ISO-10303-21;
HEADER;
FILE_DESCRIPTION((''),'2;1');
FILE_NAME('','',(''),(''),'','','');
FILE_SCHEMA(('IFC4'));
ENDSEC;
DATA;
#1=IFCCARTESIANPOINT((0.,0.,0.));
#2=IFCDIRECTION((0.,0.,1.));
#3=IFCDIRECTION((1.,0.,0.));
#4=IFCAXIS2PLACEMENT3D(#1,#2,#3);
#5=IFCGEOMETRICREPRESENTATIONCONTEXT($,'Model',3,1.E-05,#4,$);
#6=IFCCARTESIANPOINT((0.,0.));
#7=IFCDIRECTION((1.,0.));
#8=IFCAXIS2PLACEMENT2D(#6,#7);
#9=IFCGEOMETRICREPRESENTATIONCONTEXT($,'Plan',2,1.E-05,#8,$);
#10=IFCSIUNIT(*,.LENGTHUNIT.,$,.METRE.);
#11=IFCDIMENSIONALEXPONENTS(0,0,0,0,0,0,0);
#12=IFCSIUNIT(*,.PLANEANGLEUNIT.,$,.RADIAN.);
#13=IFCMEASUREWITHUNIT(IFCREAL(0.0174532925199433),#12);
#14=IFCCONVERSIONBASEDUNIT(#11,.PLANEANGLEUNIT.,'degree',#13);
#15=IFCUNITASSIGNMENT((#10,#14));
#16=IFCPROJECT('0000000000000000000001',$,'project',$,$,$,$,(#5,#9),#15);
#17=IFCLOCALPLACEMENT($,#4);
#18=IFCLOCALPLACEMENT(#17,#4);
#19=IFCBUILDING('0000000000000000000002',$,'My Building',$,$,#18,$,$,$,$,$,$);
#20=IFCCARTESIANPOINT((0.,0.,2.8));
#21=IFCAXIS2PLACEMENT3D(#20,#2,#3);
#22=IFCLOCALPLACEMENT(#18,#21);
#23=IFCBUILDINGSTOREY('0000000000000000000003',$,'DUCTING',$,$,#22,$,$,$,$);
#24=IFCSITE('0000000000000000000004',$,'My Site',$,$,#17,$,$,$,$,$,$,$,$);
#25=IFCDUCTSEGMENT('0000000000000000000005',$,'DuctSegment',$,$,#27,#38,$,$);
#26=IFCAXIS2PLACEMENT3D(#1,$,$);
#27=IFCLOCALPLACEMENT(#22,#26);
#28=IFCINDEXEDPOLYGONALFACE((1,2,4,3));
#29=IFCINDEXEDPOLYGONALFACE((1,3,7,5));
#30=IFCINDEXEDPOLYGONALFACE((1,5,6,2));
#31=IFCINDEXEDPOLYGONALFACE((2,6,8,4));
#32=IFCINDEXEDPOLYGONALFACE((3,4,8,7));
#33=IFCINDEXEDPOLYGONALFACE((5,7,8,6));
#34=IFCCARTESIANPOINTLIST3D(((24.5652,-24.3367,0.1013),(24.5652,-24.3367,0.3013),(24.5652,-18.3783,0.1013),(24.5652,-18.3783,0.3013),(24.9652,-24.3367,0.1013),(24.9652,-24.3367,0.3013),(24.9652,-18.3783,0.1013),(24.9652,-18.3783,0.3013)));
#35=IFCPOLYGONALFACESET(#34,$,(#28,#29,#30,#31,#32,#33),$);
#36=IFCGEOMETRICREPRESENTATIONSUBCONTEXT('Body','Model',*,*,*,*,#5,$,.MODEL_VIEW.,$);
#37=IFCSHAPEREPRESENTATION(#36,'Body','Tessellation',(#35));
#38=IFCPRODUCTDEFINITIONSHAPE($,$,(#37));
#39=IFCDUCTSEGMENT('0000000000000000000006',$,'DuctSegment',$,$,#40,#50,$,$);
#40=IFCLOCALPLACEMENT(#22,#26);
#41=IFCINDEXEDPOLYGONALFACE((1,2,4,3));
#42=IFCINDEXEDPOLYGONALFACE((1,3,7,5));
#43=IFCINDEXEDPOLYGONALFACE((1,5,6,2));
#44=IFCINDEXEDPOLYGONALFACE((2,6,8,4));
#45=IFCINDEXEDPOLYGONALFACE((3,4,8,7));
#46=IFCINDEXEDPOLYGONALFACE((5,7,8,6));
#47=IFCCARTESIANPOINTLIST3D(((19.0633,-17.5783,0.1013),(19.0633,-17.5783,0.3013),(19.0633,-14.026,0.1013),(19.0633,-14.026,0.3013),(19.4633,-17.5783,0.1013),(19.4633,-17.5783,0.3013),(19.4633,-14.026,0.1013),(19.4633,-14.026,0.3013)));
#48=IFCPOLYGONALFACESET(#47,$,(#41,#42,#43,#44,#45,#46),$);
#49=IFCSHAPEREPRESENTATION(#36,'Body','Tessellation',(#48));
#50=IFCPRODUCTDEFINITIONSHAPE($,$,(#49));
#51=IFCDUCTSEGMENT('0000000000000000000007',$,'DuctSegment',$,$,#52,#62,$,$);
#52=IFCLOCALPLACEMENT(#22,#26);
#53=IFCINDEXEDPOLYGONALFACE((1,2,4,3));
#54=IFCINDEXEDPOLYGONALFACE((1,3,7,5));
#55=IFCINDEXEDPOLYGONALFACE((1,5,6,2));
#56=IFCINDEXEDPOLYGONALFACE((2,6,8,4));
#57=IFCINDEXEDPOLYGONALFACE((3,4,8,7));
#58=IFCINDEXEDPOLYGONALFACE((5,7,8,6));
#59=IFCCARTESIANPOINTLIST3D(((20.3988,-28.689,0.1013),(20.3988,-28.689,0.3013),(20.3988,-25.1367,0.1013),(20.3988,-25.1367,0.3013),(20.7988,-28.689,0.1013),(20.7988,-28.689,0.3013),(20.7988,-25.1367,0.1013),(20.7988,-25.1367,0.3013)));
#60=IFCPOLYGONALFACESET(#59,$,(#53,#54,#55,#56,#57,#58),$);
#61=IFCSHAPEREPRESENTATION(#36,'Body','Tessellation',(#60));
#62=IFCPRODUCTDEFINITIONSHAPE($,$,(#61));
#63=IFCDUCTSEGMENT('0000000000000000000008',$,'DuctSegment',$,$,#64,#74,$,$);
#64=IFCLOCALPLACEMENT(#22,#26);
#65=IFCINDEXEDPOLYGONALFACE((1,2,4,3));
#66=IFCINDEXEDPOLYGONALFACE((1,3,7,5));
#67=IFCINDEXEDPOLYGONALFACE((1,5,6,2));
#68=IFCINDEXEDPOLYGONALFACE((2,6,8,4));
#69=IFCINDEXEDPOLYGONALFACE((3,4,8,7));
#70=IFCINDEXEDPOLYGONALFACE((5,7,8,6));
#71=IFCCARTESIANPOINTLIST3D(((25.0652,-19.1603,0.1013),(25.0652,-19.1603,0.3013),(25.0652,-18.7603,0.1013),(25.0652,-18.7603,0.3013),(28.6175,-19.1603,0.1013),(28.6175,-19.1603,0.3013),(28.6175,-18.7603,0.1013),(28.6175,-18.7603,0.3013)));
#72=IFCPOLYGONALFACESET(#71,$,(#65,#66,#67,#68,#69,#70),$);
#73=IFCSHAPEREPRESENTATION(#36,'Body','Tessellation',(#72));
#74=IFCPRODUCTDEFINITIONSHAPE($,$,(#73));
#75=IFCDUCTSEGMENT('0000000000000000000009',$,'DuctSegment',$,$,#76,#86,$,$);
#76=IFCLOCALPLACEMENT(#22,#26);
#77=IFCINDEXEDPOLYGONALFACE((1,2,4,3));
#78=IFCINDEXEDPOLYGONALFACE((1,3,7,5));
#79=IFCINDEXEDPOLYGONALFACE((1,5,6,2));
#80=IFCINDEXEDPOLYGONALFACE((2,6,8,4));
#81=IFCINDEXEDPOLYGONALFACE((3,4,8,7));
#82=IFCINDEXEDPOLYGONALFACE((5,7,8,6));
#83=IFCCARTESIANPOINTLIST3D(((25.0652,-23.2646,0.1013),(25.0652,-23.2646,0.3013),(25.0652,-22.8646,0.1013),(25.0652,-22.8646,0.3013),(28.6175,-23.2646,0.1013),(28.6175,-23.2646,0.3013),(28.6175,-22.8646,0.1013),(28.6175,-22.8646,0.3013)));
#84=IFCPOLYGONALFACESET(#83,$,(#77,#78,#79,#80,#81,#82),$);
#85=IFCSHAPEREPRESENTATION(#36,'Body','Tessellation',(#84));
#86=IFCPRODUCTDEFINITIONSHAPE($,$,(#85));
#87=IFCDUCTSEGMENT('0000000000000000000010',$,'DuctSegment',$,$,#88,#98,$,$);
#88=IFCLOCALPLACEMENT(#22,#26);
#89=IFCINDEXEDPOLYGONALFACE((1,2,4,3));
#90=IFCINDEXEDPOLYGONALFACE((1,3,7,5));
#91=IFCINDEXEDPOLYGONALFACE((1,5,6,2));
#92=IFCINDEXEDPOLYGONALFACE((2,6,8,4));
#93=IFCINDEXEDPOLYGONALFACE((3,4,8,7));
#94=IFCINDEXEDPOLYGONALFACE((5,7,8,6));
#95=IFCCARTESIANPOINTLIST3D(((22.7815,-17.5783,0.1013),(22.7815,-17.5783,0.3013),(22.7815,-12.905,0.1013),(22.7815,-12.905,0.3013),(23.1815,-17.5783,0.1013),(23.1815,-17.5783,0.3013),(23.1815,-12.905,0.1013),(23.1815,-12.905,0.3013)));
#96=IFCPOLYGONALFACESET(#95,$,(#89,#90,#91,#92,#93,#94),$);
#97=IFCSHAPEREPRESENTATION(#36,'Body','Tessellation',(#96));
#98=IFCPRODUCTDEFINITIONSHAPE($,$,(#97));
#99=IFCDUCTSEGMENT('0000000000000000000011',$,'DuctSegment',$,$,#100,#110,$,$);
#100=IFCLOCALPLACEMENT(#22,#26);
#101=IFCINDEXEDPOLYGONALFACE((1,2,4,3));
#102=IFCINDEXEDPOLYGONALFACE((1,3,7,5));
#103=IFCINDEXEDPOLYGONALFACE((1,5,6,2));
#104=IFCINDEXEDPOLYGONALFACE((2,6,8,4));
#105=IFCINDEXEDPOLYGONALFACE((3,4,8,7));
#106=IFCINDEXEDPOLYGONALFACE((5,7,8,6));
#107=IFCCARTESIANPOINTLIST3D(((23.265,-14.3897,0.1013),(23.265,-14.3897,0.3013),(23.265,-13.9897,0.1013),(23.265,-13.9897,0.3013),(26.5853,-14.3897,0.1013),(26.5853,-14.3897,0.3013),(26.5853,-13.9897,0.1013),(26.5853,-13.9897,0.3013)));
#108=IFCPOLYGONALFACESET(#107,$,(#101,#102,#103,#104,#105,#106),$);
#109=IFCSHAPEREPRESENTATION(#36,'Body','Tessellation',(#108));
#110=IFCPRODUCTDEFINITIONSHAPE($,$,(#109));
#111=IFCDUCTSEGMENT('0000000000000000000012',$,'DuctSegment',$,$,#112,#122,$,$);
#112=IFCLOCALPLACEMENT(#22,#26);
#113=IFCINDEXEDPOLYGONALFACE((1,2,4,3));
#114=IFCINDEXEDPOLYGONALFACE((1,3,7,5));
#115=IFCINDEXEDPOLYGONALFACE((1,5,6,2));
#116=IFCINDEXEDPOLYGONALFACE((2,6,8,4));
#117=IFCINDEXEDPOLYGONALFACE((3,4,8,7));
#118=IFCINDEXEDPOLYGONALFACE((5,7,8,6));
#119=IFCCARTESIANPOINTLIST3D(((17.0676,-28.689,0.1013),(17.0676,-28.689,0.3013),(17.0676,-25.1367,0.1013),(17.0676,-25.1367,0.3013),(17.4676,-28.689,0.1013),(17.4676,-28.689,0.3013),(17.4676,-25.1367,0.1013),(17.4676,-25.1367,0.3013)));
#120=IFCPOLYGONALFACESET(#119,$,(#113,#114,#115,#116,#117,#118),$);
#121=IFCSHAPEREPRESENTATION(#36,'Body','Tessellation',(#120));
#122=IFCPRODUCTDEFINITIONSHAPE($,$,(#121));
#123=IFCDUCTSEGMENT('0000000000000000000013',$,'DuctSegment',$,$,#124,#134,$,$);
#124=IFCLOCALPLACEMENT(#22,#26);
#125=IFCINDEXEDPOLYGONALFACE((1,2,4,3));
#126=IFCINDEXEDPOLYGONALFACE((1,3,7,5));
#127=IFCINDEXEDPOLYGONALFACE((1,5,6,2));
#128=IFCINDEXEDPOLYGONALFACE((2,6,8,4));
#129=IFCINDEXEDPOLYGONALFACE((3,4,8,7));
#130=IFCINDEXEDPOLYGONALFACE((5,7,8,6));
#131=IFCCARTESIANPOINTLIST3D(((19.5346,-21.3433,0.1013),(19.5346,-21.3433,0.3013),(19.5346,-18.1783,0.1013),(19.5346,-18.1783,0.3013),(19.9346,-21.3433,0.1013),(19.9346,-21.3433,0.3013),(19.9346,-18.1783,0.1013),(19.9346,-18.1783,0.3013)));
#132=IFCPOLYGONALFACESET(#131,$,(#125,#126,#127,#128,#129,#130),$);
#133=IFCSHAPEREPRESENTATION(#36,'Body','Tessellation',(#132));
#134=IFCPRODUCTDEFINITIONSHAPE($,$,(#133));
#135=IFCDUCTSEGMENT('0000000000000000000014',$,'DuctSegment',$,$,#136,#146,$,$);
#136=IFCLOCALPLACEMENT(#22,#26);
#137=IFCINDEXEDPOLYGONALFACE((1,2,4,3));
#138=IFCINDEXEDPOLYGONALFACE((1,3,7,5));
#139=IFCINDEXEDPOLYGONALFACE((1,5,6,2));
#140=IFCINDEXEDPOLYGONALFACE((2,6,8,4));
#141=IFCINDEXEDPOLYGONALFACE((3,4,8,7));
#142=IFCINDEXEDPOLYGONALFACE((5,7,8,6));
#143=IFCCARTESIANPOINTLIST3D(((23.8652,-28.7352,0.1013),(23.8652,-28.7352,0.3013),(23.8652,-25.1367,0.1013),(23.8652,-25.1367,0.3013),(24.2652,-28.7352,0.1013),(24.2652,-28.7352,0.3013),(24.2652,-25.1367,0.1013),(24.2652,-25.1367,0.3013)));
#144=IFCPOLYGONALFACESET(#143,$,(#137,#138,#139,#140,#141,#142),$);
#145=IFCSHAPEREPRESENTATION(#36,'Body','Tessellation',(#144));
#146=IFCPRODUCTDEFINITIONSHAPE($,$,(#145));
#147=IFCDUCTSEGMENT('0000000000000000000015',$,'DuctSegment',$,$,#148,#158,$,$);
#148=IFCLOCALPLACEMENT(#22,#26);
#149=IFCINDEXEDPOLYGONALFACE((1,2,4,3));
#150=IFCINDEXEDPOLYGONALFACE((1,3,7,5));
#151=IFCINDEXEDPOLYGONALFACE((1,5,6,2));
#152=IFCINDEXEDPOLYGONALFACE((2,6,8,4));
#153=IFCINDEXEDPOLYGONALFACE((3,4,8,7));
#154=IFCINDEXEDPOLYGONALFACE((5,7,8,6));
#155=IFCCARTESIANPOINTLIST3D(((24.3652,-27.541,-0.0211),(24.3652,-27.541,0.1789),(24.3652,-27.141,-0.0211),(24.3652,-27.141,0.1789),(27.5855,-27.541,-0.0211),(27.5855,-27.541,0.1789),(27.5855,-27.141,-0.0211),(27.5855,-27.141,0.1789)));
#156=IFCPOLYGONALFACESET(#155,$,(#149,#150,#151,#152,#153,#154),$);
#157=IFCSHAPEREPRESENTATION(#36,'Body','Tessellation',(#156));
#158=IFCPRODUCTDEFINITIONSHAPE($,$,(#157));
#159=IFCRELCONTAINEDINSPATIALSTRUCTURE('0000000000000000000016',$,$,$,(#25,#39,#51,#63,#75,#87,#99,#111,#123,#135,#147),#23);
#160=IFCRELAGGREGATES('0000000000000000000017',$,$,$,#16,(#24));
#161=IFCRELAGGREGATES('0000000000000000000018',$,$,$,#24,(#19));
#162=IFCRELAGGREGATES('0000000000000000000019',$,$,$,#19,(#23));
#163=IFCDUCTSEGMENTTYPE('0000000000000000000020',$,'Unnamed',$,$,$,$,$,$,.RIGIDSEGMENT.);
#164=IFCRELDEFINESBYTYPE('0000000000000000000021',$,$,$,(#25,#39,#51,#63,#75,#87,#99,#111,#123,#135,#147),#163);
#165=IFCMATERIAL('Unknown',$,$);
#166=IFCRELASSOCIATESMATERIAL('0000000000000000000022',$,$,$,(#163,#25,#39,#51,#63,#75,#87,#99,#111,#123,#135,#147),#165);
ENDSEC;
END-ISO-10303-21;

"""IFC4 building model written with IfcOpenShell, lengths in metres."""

from ifc_helpers import new_model, entity, si_unit, converted_unit, frame, origin_with_axes, origin_2d_with_axis, place, context, subcontext, project, spatial, rectangle, extrude, material, material_profile, profile_set, profile_usage, type_object, element, save


model = new_model("IFC4")

# Units and contexts
model_context = context("Model", 3, precision=1e-05, world=origin_with_axes())
plan_context = context("Plan", 2, precision=1e-05, world=origin_2d_with_axis())
body_context = subcontext(model_context, "Body", "Model", "MODEL_VIEW")
ifc_project = project(units=[si_unit("LENGTHUNIT", "METRE"), converted_unit("PLANEANGLEUNIT", "degree", entity("IfcReal", 0.0174532925199433), si_unit("PLANEANGLEUNIT", "RADIAN"), dimensions=[0, 0, 0, 0, 0, 0, 0])], contexts=[model_context, plan_context])

# Site, building, storey
site_placement = place(None, origin_with_axes())
site = spatial("IfcSite", under=ifc_project, at=site_placement, Name="My Site")
building_placement = place(site_placement, origin_with_axes())
building = spatial("IfcBuilding", under=site, at=building_placement, Name="My Building")
storey_placement = place(building_placement, frame((0.0, 0.0, 2.8), z_axis=(0.0, 0.0, 1.0), x_axis=(1.0, 0.0, 0.0)))
storey = spatial("IfcBuildingStorey", under=building, at=storey_placement, Name="DUCTING")

# Duct segments
ifc_material = material(Name="Unknown")
ifc_material_profile_1 = material_profile(ifc_material, rectangle(XDim=0.4, YDim=0.2))
ifc_profile_set_1 = profile_set([ifc_material_profile_1])
ifc_profile_usage_1 = profile_usage(ifc_profile_set_1, cardinal=5)
duct_segment_type = type_object("IfcDuctSegmentType", Name="Unnamed", PredefinedType="RIGIDSEGMENT", material=ifc_profile_set_1)
duct_segment_1_placement = place(storey_placement, frame((24.7652, -18.3783, 0.2013), z_axis=(0.0, -1.0, 0.0), x_axis=(1.0, 0.0, 0.0)))
element("IfcDuctSegment", 1, at=duct_segment_1_placement, inside=storey, type_object=duct_segment_type, material=ifc_profile_usage_1, Name="DuctSegment", context=body_context, shape_type="SweptSolid", body=[
    extrude(rectangle(XDim=0.4, YDim=0.2), origin_with_axes(), (0.0, 0.0, 1.0), 5.9584),
])
ifc_profile_usage_2 = profile_usage(ifc_profile_set_1, cardinal=5)
duct_segment_2_placement = place(storey_placement, frame((19.2633, -17.5783, 0.2013), z_axis=(0.0, 1.0, 0.0), x_axis=(-1.0, 0.0, 0.0)))
element("IfcDuctSegment", 2, at=duct_segment_2_placement, inside=storey, type_object=duct_segment_type, material=ifc_profile_usage_2, Name="DuctSegment", context=body_context, shape_type="SweptSolid", body=[
    extrude(rectangle(XDim=0.4, YDim=0.2), origin_with_axes(), (0.0, 0.0, 1.0), 3.5523),
])
ifc_profile_usage_3 = profile_usage(ifc_profile_set_1, cardinal=5)
duct_segment_3_placement = place(storey_placement, frame((20.5988, -25.1367, 0.2013), z_axis=(0.0, -1.0, 0.0), x_axis=(1.0, 0.0, 0.0)))
element("IfcDuctSegment", 3, at=duct_segment_3_placement, inside=storey, type_object=duct_segment_type, material=ifc_profile_usage_3, Name="DuctSegment", context=body_context, shape_type="SweptSolid", body=[
    extrude(rectangle(XDim=0.4, YDim=0.2), origin_with_axes(), (0.0, 0.0, 1.0), 3.5523),
])
ifc_profile_usage_4 = profile_usage(ifc_profile_set_1, cardinal=5)
duct_segment_4_placement = place(storey_placement, frame((25.0652, -18.9603, 0.2013), z_axis=(1.0, 0.0, 0.0), x_axis=(0.0, 1.0, 0.0)))
element("IfcDuctSegment", 4, at=duct_segment_4_placement, inside=storey, type_object=duct_segment_type, material=ifc_profile_usage_4, Name="DuctSegment", context=body_context, shape_type="SweptSolid", body=[
    extrude(rectangle(XDim=0.4, YDim=0.2), origin_with_axes(), (0.0, 0.0, 1.0), 3.5523),
])
ifc_profile_usage_5 = profile_usage(ifc_profile_set_1, cardinal=5)
duct_segment_5_placement = place(storey_placement, frame((25.0652, -23.0646, 0.2013), z_axis=(1.0, 0.0, 0.0), x_axis=(0.0, 1.0, 0.0)))
element("IfcDuctSegment", 5, at=duct_segment_5_placement, inside=storey, type_object=duct_segment_type, material=ifc_profile_usage_5, Name="DuctSegment", context=body_context, shape_type="SweptSolid", body=[
    extrude(rectangle(XDim=0.4, YDim=0.2), origin_with_axes(), (0.0, 0.0, 1.0), 3.5523),
])
ifc_profile_usage_6 = profile_usage(ifc_profile_set_1, cardinal=5)
duct_segment_6_placement = place(storey_placement, frame((22.9815, -17.5783, 0.2013), z_axis=(0.0, 1.0, 0.0), x_axis=(-1.0, 0.0, 0.0)))
element("IfcDuctSegment", 6, at=duct_segment_6_placement, inside=storey, type_object=duct_segment_type, material=ifc_profile_usage_6, Name="DuctSegment", context=body_context, shape_type="SweptSolid", body=[
    extrude(rectangle(XDim=0.4, YDim=0.2), origin_with_axes(), (0.0, 0.0, 1.0), 4.6733),
])
ifc_profile_usage_7 = profile_usage(ifc_profile_set_1, cardinal=5)
duct_segment_7_placement = place(storey_placement, frame((23.265, -14.1897, 0.2013), z_axis=(1.0, -0.000001, 0.000001), x_axis=(0.000001, 1.0, 0.0)))
element("IfcDuctSegment", 7, at=duct_segment_7_placement, inside=storey, type_object=duct_segment_type, material=ifc_profile_usage_7, Name="DuctSegment", context=body_context, shape_type="SweptSolid", body=[
    extrude(rectangle(XDim=0.4, YDim=0.2), origin_with_axes(), (0.0, 0.0, 1.0), 3.3202),
])
ifc_profile_usage_8 = profile_usage(ifc_profile_set_1, cardinal=5)
duct_segment_8_placement = place(storey_placement, frame((17.2676, -25.1367, 0.2013), z_axis=(0.0, -1.0, 0.0), x_axis=(1.0, 0.0, 0.0)))
element("IfcDuctSegment", 8, at=duct_segment_8_placement, inside=storey, type_object=duct_segment_type, material=ifc_profile_usage_8, Name="DuctSegment", context=body_context, shape_type="SweptSolid", body=[
    extrude(rectangle(XDim=0.4, YDim=0.2), origin_with_axes(), (0.0, 0.0, 1.0), 3.5523),
])
ifc_profile_usage_9 = profile_usage(ifc_profile_set_1, cardinal=5)
duct_segment_9_placement = place(storey_placement, frame((19.7346, -18.1783, 0.2013), z_axis=(0.0, -1.0, 0.0), x_axis=(1.0, 0.0, 0.0)))
element("IfcDuctSegment", 9, at=duct_segment_9_placement, inside=storey, type_object=duct_segment_type, material=ifc_profile_usage_9, Name="DuctSegment", context=body_context, shape_type="SweptSolid", body=[
    extrude(rectangle(XDim=0.4, YDim=0.2), origin_with_axes(), (0.0, 0.0, 1.0), 3.165),
])
ifc_profile_usage_10 = profile_usage(ifc_profile_set_1, cardinal=5)
duct_segment_10_placement = place(storey_placement, frame((24.0652, -25.1367, 0.2013), z_axis=(0.0, -1.0, 0.0), x_axis=(1.0, 0.0, 0.0)))
element("IfcDuctSegment", 10, at=duct_segment_10_placement, inside=storey, type_object=duct_segment_type, material=ifc_profile_usage_10, Name="DuctSegment", context=body_context, shape_type="SweptSolid", body=[
    extrude(rectangle(XDim=0.4, YDim=0.2), origin_with_axes(), (0.0, 0.0, 1.0), 3.5985),
])
ifc_profile_usage_11 = profile_usage(ifc_profile_set_1, cardinal=5)
duct_segment_11_placement = place(storey_placement, frame((24.3652, -27.341, 0.0789), z_axis=(1.0, -0.000001, 0.000001), x_axis=(0.000001, 1.0, 0.0)))
element("IfcDuctSegment", 11, at=duct_segment_11_placement, inside=storey, type_object=duct_segment_type, material=ifc_profile_usage_11, Name="DuctSegment", context=body_context, shape_type="SweptSolid", body=[
    extrude(rectangle(XDim=0.4, YDim=0.2), origin_with_axes(), (0.0, 0.0, 1.0), 3.2202),
])

save(model, "model.ifc")
